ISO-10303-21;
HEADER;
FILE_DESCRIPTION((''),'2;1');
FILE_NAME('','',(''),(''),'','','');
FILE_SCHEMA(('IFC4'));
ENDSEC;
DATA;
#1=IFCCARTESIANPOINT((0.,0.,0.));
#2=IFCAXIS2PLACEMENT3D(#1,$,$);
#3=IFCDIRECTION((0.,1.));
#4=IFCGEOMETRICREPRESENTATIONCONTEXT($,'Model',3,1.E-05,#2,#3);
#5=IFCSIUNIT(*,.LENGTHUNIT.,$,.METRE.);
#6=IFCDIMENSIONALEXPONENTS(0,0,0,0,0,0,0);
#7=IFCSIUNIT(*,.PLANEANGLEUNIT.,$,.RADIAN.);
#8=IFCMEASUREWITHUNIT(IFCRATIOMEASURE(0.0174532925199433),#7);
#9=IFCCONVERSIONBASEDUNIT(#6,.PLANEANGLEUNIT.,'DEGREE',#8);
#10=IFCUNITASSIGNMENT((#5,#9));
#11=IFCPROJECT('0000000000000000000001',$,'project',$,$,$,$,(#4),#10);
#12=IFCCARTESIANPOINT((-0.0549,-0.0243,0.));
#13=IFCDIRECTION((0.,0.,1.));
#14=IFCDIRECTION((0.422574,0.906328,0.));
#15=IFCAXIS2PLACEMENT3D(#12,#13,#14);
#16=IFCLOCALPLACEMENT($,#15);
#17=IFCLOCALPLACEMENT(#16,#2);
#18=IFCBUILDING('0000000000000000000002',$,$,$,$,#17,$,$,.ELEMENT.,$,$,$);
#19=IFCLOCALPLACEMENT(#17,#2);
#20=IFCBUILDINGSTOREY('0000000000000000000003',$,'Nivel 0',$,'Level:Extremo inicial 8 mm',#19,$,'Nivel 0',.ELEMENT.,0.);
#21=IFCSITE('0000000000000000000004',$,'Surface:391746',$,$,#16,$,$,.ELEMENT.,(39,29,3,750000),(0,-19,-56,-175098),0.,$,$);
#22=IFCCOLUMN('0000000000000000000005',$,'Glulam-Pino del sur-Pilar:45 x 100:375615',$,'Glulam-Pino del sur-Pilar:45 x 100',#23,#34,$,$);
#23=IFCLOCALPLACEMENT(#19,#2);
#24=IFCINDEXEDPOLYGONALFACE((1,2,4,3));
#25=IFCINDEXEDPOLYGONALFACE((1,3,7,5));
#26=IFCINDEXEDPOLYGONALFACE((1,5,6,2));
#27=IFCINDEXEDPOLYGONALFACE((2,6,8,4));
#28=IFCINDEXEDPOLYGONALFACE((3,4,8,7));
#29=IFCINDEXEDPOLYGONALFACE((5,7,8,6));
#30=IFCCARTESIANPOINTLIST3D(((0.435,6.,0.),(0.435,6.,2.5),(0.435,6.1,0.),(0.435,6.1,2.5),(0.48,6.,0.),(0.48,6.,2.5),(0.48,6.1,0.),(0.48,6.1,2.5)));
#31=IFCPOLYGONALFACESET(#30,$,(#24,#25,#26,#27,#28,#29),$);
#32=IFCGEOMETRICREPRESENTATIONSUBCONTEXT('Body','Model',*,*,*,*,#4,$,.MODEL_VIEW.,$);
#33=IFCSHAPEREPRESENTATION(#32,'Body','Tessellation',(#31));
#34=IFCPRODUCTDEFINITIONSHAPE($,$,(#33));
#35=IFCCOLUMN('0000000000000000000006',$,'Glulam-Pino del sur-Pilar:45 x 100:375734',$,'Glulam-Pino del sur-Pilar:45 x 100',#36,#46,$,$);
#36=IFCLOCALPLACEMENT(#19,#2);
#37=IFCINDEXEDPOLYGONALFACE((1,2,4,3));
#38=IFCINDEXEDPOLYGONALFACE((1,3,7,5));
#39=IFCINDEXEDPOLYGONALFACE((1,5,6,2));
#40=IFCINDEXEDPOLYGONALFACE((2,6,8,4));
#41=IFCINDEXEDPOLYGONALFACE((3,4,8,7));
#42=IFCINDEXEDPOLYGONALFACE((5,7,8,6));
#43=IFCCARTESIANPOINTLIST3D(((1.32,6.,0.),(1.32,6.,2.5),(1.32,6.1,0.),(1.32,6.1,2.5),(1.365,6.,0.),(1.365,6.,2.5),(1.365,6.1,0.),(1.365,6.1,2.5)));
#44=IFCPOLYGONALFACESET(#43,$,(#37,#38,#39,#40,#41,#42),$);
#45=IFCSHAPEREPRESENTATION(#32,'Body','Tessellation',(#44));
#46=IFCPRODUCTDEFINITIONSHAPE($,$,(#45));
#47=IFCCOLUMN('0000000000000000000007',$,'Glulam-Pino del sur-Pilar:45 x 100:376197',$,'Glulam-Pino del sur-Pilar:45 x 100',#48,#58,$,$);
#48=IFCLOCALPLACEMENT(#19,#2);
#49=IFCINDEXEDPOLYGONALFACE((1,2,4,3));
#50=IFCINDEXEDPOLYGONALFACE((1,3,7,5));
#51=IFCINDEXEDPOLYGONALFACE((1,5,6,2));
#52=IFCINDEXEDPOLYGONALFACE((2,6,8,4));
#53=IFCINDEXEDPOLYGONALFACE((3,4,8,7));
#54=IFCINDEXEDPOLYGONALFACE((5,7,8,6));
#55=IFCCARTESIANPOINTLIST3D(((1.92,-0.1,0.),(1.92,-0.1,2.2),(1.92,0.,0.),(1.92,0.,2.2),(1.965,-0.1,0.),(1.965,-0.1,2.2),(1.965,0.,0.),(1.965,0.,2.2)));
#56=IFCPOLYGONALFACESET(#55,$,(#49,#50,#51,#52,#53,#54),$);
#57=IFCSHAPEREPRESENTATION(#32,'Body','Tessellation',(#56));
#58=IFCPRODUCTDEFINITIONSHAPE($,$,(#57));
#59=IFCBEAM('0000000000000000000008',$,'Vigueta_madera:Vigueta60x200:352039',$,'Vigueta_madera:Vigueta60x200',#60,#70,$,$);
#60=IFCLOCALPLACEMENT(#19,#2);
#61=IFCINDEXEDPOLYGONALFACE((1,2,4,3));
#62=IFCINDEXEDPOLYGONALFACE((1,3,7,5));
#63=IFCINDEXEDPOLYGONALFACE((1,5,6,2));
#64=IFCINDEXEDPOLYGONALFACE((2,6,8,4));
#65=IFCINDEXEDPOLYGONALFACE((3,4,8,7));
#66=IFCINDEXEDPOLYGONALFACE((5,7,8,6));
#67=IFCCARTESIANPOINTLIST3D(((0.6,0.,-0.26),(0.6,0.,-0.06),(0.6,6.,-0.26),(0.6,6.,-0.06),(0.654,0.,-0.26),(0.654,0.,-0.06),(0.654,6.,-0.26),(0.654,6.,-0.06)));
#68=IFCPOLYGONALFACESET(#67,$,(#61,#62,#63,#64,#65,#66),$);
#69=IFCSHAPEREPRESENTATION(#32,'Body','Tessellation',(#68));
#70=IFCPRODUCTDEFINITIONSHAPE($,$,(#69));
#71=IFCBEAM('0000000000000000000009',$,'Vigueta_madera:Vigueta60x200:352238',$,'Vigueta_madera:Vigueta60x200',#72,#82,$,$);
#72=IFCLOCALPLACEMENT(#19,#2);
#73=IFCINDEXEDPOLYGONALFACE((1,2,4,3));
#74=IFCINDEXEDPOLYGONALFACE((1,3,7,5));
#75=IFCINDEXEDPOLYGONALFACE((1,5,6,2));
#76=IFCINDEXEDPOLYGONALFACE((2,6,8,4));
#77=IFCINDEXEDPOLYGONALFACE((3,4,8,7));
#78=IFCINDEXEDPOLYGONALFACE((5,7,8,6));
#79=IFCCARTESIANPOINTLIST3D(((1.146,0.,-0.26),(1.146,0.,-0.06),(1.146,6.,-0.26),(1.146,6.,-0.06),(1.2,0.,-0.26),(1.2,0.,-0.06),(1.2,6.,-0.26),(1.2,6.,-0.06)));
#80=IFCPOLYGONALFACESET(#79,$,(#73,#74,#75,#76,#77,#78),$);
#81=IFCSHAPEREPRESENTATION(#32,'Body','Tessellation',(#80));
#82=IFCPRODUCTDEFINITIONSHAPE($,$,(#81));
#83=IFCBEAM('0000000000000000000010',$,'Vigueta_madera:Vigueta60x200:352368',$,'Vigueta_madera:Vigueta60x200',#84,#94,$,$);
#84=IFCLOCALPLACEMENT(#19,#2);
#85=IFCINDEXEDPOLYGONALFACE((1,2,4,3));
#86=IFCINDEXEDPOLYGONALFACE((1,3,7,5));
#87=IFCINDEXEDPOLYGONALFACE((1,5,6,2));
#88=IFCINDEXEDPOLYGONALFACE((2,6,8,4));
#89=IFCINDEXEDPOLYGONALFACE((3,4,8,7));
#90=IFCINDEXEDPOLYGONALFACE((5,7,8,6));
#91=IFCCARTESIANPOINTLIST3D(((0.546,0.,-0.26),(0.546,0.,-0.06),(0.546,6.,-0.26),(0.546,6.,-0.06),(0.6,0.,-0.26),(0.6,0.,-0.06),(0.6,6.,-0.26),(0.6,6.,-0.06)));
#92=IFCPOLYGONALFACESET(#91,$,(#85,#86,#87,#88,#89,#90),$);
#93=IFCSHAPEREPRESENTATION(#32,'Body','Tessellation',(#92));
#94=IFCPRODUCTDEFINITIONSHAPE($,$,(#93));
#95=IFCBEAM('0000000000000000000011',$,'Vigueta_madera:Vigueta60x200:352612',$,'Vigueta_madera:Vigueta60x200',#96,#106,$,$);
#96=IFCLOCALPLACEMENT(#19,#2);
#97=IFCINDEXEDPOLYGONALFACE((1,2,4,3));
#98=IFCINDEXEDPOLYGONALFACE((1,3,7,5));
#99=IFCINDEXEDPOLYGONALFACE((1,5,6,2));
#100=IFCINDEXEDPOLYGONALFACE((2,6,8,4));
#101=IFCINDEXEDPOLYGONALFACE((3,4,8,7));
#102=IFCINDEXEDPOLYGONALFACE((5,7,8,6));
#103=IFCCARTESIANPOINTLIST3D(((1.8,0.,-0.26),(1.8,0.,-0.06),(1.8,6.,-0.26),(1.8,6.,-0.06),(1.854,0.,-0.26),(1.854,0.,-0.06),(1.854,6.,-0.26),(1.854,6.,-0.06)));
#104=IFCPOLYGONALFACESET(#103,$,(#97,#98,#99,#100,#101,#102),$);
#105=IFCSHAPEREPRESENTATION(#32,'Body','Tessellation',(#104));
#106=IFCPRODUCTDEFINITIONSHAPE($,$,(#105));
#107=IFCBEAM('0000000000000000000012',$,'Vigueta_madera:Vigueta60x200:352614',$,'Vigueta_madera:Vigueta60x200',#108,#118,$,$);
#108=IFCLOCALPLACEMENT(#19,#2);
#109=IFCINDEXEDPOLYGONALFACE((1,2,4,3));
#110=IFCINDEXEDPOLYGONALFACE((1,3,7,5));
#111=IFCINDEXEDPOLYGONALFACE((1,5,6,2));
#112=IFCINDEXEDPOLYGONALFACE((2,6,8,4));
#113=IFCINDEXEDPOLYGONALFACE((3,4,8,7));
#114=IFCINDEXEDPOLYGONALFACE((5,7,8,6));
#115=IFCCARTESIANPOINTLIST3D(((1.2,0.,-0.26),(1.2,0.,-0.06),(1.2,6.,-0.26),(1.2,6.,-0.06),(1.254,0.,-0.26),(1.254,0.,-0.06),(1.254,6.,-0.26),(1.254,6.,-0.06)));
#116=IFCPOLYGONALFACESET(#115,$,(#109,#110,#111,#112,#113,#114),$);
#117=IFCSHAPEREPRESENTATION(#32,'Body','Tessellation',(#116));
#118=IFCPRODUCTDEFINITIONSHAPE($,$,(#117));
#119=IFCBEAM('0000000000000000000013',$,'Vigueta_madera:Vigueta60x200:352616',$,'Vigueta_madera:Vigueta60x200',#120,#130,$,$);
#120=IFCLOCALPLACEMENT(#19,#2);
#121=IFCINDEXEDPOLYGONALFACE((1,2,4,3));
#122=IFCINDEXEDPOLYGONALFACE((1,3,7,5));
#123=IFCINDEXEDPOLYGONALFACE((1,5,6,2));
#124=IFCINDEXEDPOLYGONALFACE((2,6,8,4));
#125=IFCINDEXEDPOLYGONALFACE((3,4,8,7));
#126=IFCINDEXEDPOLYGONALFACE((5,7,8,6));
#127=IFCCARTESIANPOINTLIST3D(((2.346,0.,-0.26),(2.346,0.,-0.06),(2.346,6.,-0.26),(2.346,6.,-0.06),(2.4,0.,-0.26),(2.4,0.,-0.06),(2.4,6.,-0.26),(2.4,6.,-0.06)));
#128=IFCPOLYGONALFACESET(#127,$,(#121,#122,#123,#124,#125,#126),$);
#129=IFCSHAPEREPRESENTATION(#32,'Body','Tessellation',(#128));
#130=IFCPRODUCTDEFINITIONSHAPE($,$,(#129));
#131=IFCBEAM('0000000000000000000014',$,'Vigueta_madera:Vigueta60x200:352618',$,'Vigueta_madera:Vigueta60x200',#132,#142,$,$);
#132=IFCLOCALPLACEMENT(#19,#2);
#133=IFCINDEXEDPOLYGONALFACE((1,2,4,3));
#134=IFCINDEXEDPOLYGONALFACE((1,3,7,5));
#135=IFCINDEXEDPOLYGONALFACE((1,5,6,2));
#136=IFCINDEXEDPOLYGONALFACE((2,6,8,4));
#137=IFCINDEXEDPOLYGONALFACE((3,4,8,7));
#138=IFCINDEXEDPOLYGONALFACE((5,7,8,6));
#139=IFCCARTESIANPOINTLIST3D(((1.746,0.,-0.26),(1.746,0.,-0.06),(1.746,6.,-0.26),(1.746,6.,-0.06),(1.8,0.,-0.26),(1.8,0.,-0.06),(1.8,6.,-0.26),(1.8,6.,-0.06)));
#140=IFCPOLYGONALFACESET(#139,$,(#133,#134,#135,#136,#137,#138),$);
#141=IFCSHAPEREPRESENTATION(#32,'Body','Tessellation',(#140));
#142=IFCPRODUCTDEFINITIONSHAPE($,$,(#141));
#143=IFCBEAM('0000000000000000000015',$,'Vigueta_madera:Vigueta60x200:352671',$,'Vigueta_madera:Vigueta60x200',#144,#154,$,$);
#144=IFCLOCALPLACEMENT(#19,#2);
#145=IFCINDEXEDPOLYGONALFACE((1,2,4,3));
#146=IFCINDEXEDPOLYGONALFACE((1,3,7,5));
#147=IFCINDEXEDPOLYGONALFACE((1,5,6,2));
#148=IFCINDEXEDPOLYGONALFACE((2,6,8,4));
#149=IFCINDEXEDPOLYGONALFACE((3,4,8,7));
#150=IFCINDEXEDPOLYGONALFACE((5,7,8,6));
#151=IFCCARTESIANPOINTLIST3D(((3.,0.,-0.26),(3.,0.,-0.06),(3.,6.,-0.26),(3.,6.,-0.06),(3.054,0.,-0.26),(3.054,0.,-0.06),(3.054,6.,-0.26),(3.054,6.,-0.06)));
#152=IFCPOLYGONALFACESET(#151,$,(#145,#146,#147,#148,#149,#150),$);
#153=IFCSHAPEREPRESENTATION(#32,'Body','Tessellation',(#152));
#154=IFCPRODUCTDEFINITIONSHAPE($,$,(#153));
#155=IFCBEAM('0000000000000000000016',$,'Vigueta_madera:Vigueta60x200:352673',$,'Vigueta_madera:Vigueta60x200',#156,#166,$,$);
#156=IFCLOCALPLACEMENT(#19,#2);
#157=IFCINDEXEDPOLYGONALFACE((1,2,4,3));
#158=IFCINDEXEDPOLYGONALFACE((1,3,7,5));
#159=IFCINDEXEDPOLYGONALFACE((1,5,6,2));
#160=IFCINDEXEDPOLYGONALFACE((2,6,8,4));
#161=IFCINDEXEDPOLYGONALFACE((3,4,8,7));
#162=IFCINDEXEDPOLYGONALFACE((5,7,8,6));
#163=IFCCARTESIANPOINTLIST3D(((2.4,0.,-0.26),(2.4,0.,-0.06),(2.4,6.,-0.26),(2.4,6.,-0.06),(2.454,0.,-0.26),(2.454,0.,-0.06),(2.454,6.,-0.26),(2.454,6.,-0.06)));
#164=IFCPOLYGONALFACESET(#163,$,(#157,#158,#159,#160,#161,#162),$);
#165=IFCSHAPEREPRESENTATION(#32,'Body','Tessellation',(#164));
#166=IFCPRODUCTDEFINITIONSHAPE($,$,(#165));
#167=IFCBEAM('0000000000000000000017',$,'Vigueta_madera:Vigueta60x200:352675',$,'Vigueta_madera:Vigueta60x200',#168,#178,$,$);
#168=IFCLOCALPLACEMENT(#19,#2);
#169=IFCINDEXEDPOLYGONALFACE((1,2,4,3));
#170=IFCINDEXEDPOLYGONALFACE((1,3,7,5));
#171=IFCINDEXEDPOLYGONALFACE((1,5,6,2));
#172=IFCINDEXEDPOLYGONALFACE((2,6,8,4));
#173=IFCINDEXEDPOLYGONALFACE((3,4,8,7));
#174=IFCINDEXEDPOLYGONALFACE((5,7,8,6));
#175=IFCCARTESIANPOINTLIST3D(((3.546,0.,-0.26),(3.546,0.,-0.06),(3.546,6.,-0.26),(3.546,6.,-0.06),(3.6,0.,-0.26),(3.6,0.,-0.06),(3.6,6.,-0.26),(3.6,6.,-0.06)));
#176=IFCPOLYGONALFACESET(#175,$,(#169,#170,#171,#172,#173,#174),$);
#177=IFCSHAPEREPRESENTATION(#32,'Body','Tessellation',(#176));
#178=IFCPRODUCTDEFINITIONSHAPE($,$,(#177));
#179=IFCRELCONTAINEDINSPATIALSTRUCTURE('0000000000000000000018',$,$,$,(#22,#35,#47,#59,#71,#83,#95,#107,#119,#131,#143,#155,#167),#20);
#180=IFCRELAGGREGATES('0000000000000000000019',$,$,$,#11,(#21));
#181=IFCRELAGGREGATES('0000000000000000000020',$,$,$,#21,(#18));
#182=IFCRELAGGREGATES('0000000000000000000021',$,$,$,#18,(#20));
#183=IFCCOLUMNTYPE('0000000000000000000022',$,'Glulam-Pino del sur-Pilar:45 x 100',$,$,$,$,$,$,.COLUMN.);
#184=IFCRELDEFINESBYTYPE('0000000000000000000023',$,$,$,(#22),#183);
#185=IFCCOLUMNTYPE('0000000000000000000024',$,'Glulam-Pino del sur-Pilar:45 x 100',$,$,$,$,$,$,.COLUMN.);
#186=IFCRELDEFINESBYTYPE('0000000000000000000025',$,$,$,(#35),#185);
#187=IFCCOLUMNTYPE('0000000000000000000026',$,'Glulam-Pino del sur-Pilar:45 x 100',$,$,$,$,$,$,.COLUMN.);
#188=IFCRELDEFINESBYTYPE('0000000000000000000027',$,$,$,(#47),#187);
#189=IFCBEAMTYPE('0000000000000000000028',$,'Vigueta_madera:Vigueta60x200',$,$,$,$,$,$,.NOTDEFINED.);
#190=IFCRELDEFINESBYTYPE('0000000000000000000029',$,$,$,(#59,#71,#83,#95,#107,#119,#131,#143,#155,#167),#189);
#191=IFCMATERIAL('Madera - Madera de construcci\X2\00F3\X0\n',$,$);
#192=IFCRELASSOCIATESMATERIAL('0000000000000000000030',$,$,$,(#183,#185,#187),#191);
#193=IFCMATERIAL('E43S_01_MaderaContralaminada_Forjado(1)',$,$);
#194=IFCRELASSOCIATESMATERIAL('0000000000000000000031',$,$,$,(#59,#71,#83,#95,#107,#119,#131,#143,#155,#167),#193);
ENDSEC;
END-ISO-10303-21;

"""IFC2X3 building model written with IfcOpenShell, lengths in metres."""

from ifc_helpers import new_model, entity, si_unit, converted_unit, direction, frame, frame_2d, origin, origin_2d_with_axis, place, context, subcontext, project, spatial, rectangle, extrude, source, transform, mapped, material, type_object, type_shapes, element, save


model = new_model("IFC2X3")

# Units and contexts
model_context = context("Model", 3, precision=1e-05, world=origin(), true_north=direction((0.0, 1.0)))
body_context = subcontext(model_context, "Body", "Model", "MODEL_VIEW")
ifc_project = project(units=[si_unit("LENGTHUNIT", "METRE"), converted_unit("PLANEANGLEUNIT", "DEGREE", entity("IfcRatioMeasure", 0.0174532925199433), si_unit("PLANEANGLEUNIT", "RADIAN"), dimensions=[0, 0, 0, 0, 0, 0, 0])], contexts=[model_context])

# Site, building, storey
site_placement = place(None, frame((-0.0549, -0.0243, 0.0), z_axis=(0.0, 0.0, 1.0), x_axis=(0.422574, 0.906328, 0.0)))
site = spatial("IfcSite", under=ifc_project, at=site_placement, Name="Surface:391746", CompositionType="ELEMENT", RefLatitude=(39, 29, 3, 750000), RefLongitude=(0, -19, -56, -175098), RefElevation=0.0)
building_placement = place(site_placement, origin())
building = spatial("IfcBuilding", under=site, at=building_placement, CompositionType="ELEMENT")
storey_placement = place(building_placement, origin())
storey = spatial("IfcBuildingStorey", under=building, at=storey_placement, Name="Nivel 0", ObjectType="Level:Extremo inicial 8 mm", LongName="Nivel 0", CompositionType="ELEMENT", Elevation=0.0)

# Columns
ifc_material_1 = material(Name="Madera - Madera de construcción")
column_type_1 = type_object("IfcColumnType", Name="Glulam-Pino del sur-Pilar:45 x 100", PredefinedType="COLUMN", material=ifc_material_1)
shared_shape_1 = source(origin(), body_context, "Body", "SweptSolid", [
    extrude(rectangle(XDim=0.1, YDim=0.045, at=origin_2d_with_axis()), frame((0.0, 0.0, 0.0), z_axis=(0.0, 0.0, 1.0), x_axis=(0.0, -1.0, 0.0)), (0.0, 0.0, 1.0), 2.5),
])
type_shapes(column_type_1, [shared_shape_1])
column_1_placement = place(storey_placement, frame((0.4575, 6.05, 0.0)))
element("IfcColumn", 1, at=column_1_placement, inside=storey, type_object=column_type_1, Name="Glulam-Pino del sur-Pilar:45 x 100:375615", ObjectType="Glulam-Pino del sur-Pilar:45 x 100", context=body_context, shape_type="MappedRepresentation", body=[
    mapped(shared_shape_1, transform((0.0, 0.0, 0.0), scale=1.0)),
])
column_type_2 = type_object("IfcColumnType", Name="Glulam-Pino del sur-Pilar:45 x 100", PredefinedType="COLUMN", material=ifc_material_1)
shared_shape_2 = source(origin(), body_context, "Body", "SweptSolid", [
    extrude(rectangle(XDim=0.1, YDim=0.045, at=origin_2d_with_axis()), frame((0.0, 0.0, 0.0), z_axis=(0.0, 0.0, 1.0), x_axis=(0.0, -1.0, 0.0)), (0.0, 0.0, 1.0), 2.5),
])
type_shapes(column_type_2, [shared_shape_2])
column_2_placement = place(storey_placement, frame((1.3425, 6.05, 0.0), z_axis=(0.0, 0.0, 1.0), x_axis=(-1.0, 0.0, 0.0)))
element("IfcColumn", 2, at=column_2_placement, inside=storey, type_object=column_type_2, Name="Glulam-Pino del sur-Pilar:45 x 100:375734", ObjectType="Glulam-Pino del sur-Pilar:45 x 100", context=body_context, shape_type="MappedRepresentation", body=[
    mapped(shared_shape_2, transform((0.0, 0.0, 0.0), scale=1.0)),
])
column_type_3 = type_object("IfcColumnType", Name="Glulam-Pino del sur-Pilar:45 x 100", PredefinedType="COLUMN", material=ifc_material_1)
shared_shape_3 = source(origin(), body_context, "Body", "SweptSolid", [
    extrude(rectangle(XDim=0.1, YDim=0.045, at=origin_2d_with_axis()), frame((0.0, 0.0, 0.0), z_axis=(0.0, 0.0, 1.0), x_axis=(0.0, -1.0, 0.0)), (0.0, 0.0, 1.0), 2.2),
])
type_shapes(column_type_3, [shared_shape_3])
column_3_placement = place(storey_placement, frame((1.9425, -0.05, 0.0)))
element("IfcColumn", 3, at=column_3_placement, inside=storey, type_object=column_type_3, Name="Glulam-Pino del sur-Pilar:45 x 100:376197", ObjectType="Glulam-Pino del sur-Pilar:45 x 100", context=body_context, shape_type="MappedRepresentation", body=[
    mapped(shared_shape_3, transform((0.0, 0.0, 0.0), scale=1.0)),
])

# Beams
ifc_material_2 = material(Name="E43S_01_MaderaContralaminada_Forjado(1)")
beam_type = type_object("IfcBeamType", Name="Vigueta_madera:Vigueta60x200", PredefinedType="NOTDEFINED")
beam_1_placement = place(storey_placement, frame((0.627, 0.0, -0.06), z_axis=(0.0, 0.0, 1.0), x_axis=(0.0, 1.0, 0.0)))
element("IfcBeam", 4, at=beam_1_placement, inside=storey, type_object=beam_type, material=ifc_material_2, Name="Vigueta_madera:Vigueta60x200:352039", ObjectType="Vigueta_madera:Vigueta60x200", context=body_context, shape_type="SweptSolid", body=[
    extrude(rectangle(XDim=0.2, YDim=0.054, at=frame_2d((0.0, 0.0), x_axis=(1.0, 0.0))), frame((0.0, 0.0, -0.1), z_axis=(1.0, 0.0, 0.0), x_axis=(0.0, 0.0, -1.0)), (0.0, 0.0, 1.0), 6.0),
])
beam_2_placement = place(storey_placement, frame((1.173, 0.0, -0.06), z_axis=(0.0, 0.0, 1.0), x_axis=(0.0, 1.0, 0.0)))
element("IfcBeam", 5, at=beam_2_placement, inside=storey, type_object=beam_type, material=ifc_material_2, Name="Vigueta_madera:Vigueta60x200:352238", ObjectType="Vigueta_madera:Vigueta60x200", context=body_context, shape_type="SweptSolid", body=[
    extrude(rectangle(XDim=0.2, YDim=0.054, at=origin_2d_with_axis()), frame((0.0, 0.0, -0.1), z_axis=(1.0, 0.0, 0.0), x_axis=(0.0, 0.0, -1.0)), (0.0, 0.0, 1.0), 6.0),
])
beam_3_placement = place(storey_placement, frame((0.573, 0.0, -0.06), z_axis=(0.0, 0.0, 1.0), x_axis=(0.0, 1.0, 0.0)))
element("IfcBeam", 6, at=beam_3_placement, inside=storey, type_object=beam_type, material=ifc_material_2, Name="Vigueta_madera:Vigueta60x200:352368", ObjectType="Vigueta_madera:Vigueta60x200", context=body_context, shape_type="SweptSolid", body=[
    extrude(rectangle(XDim=0.2, YDim=0.054, at=frame_2d((0.0, 0.0), x_axis=(1.0, 0.0))), frame((0.0, 0.0, -0.1), z_axis=(1.0, 0.0, 0.0), x_axis=(0.0, 0.0, -1.0)), (0.0, 0.0, 1.0), 6.0),
])
beam_4_placement = place(storey_placement, frame((1.827, 0.0, -0.06), z_axis=(0.0, 0.0, 1.0), x_axis=(0.0, 1.0, 0.0)))
element("IfcBeam", 7, at=beam_4_placement, inside=storey, type_object=beam_type, material=ifc_material_2, Name="Vigueta_madera:Vigueta60x200:352612", ObjectType="Vigueta_madera:Vigueta60x200", context=body_context, shape_type="SweptSolid", body=[
    extrude(rectangle(XDim=0.2, YDim=0.054, at=frame_2d((0.0, 0.0), x_axis=(1.0, 0.0))), frame((0.0, 0.0, -0.1), z_axis=(1.0, 0.0, 0.0), x_axis=(0.0, 0.0, -1.0)), (0.0, 0.0, 1.0), 6.0),
])
beam_5_placement = place(storey_placement, frame((1.227, 0.0, -0.06), z_axis=(0.0, 0.0, 1.0), x_axis=(0.0, 1.0, 0.0)))
element("IfcBeam", 8, at=beam_5_placement, inside=storey, type_object=beam_type, material=ifc_material_2, Name="Vigueta_madera:Vigueta60x200:352614", ObjectType="Vigueta_madera:Vigueta60x200", context=body_context, shape_type="SweptSolid", body=[
    extrude(rectangle(XDim=0.2, YDim=0.054, at=origin_2d_with_axis()), frame((0.0, 0.0, -0.1), z_axis=(1.0, 0.0, 0.0), x_axis=(0.0, 0.0, -1.0)), (0.0, 0.0, 1.0), 6.0),
])
for number, where, z_axis, x_axis, name in (
    (9, (2.373, 0.0, -0.06), (0.0, 0.0, 1.0), (0.0, 1.0, 0.0), "Vigueta_madera:Vigueta60x200:352616"),
    (10, (1.773, 0.0, -0.06), (0.0, 0.0, 1.0), (0.0, 1.0, 0.0), "Vigueta_madera:Vigueta60x200:352618"),
):
    element("IfcBeam", number, at=place(storey_placement, frame(where, z_axis=z_axis, x_axis=x_axis)), inside=storey, type_object=beam_type, material=ifc_material_2, Name=name, ObjectType="Vigueta_madera:Vigueta60x200", context=body_context, shape_type="SweptSolid", body=[
        extrude(rectangle(XDim=0.2, YDim=0.054, at=origin_2d_with_axis()), frame((0.0, 0.0, -0.1), z_axis=(1.0, 0.0, 0.0), x_axis=(0.0, 0.0, -1.0)), (0.0, 0.0, 1.0), 6.0),
    ])
beam_6_placement = place(storey_placement, frame((3.027, 0.0, -0.06), z_axis=(0.0, 0.0, 1.0), x_axis=(0.0, 1.0, 0.0)))
element("IfcBeam", 11, at=beam_6_placement, inside=storey, type_object=beam_type, material=ifc_material_2, Name="Vigueta_madera:Vigueta60x200:352671", ObjectType="Vigueta_madera:Vigueta60x200", context=body_context, shape_type="SweptSolid", body=[
    extrude(rectangle(XDim=0.2, YDim=0.054, at=frame_2d((0.0, 0.0), x_axis=(1.0, 0.0))), frame((0.0, 0.0, -0.1), z_axis=(1.0, 0.0, 0.0), x_axis=(0.0, 0.0, -1.0)), (0.0, 0.0, 1.0), 6.0),
])
beam_7_placement = place(storey_placement, frame((2.427, 0.0, -0.06), z_axis=(0.0, 0.0, 1.0), x_axis=(0.0, 1.0, 0.0)))
element("IfcBeam", 12, at=beam_7_placement, inside=storey, type_object=beam_type, material=ifc_material_2, Name="Vigueta_madera:Vigueta60x200:352673", ObjectType="Vigueta_madera:Vigueta60x200", context=body_context, shape_type="SweptSolid", body=[
    extrude(rectangle(XDim=0.2, YDim=0.054, at=frame_2d((0.0, 0.0), x_axis=(1.0, 0.0))), frame((0.0, 0.0, -0.1), z_axis=(1.0, 0.0, 0.0), x_axis=(0.0, 0.0, -1.0)), (0.0, 0.0, 1.0), 6.0),
])
beam_8_placement = place(storey_placement, frame((3.573, 0.0, -0.06), z_axis=(0.0, 0.0, 1.0), x_axis=(0.0, 1.0, 0.0)))
element("IfcBeam", 13, at=beam_8_placement, inside=storey, type_object=beam_type, material=ifc_material_2, Name="Vigueta_madera:Vigueta60x200:352675", ObjectType="Vigueta_madera:Vigueta60x200", context=body_context, shape_type="SweptSolid", body=[
    extrude(rectangle(XDim=0.2, YDim=0.054, at=origin_2d_with_axis()), frame((0.0, 0.0, -0.1), z_axis=(1.0, 0.0, 0.0), x_axis=(0.0, 0.0, -1.0)), (0.0, 0.0, 1.0), 6.0),
])

save(model, "model.ifc")
